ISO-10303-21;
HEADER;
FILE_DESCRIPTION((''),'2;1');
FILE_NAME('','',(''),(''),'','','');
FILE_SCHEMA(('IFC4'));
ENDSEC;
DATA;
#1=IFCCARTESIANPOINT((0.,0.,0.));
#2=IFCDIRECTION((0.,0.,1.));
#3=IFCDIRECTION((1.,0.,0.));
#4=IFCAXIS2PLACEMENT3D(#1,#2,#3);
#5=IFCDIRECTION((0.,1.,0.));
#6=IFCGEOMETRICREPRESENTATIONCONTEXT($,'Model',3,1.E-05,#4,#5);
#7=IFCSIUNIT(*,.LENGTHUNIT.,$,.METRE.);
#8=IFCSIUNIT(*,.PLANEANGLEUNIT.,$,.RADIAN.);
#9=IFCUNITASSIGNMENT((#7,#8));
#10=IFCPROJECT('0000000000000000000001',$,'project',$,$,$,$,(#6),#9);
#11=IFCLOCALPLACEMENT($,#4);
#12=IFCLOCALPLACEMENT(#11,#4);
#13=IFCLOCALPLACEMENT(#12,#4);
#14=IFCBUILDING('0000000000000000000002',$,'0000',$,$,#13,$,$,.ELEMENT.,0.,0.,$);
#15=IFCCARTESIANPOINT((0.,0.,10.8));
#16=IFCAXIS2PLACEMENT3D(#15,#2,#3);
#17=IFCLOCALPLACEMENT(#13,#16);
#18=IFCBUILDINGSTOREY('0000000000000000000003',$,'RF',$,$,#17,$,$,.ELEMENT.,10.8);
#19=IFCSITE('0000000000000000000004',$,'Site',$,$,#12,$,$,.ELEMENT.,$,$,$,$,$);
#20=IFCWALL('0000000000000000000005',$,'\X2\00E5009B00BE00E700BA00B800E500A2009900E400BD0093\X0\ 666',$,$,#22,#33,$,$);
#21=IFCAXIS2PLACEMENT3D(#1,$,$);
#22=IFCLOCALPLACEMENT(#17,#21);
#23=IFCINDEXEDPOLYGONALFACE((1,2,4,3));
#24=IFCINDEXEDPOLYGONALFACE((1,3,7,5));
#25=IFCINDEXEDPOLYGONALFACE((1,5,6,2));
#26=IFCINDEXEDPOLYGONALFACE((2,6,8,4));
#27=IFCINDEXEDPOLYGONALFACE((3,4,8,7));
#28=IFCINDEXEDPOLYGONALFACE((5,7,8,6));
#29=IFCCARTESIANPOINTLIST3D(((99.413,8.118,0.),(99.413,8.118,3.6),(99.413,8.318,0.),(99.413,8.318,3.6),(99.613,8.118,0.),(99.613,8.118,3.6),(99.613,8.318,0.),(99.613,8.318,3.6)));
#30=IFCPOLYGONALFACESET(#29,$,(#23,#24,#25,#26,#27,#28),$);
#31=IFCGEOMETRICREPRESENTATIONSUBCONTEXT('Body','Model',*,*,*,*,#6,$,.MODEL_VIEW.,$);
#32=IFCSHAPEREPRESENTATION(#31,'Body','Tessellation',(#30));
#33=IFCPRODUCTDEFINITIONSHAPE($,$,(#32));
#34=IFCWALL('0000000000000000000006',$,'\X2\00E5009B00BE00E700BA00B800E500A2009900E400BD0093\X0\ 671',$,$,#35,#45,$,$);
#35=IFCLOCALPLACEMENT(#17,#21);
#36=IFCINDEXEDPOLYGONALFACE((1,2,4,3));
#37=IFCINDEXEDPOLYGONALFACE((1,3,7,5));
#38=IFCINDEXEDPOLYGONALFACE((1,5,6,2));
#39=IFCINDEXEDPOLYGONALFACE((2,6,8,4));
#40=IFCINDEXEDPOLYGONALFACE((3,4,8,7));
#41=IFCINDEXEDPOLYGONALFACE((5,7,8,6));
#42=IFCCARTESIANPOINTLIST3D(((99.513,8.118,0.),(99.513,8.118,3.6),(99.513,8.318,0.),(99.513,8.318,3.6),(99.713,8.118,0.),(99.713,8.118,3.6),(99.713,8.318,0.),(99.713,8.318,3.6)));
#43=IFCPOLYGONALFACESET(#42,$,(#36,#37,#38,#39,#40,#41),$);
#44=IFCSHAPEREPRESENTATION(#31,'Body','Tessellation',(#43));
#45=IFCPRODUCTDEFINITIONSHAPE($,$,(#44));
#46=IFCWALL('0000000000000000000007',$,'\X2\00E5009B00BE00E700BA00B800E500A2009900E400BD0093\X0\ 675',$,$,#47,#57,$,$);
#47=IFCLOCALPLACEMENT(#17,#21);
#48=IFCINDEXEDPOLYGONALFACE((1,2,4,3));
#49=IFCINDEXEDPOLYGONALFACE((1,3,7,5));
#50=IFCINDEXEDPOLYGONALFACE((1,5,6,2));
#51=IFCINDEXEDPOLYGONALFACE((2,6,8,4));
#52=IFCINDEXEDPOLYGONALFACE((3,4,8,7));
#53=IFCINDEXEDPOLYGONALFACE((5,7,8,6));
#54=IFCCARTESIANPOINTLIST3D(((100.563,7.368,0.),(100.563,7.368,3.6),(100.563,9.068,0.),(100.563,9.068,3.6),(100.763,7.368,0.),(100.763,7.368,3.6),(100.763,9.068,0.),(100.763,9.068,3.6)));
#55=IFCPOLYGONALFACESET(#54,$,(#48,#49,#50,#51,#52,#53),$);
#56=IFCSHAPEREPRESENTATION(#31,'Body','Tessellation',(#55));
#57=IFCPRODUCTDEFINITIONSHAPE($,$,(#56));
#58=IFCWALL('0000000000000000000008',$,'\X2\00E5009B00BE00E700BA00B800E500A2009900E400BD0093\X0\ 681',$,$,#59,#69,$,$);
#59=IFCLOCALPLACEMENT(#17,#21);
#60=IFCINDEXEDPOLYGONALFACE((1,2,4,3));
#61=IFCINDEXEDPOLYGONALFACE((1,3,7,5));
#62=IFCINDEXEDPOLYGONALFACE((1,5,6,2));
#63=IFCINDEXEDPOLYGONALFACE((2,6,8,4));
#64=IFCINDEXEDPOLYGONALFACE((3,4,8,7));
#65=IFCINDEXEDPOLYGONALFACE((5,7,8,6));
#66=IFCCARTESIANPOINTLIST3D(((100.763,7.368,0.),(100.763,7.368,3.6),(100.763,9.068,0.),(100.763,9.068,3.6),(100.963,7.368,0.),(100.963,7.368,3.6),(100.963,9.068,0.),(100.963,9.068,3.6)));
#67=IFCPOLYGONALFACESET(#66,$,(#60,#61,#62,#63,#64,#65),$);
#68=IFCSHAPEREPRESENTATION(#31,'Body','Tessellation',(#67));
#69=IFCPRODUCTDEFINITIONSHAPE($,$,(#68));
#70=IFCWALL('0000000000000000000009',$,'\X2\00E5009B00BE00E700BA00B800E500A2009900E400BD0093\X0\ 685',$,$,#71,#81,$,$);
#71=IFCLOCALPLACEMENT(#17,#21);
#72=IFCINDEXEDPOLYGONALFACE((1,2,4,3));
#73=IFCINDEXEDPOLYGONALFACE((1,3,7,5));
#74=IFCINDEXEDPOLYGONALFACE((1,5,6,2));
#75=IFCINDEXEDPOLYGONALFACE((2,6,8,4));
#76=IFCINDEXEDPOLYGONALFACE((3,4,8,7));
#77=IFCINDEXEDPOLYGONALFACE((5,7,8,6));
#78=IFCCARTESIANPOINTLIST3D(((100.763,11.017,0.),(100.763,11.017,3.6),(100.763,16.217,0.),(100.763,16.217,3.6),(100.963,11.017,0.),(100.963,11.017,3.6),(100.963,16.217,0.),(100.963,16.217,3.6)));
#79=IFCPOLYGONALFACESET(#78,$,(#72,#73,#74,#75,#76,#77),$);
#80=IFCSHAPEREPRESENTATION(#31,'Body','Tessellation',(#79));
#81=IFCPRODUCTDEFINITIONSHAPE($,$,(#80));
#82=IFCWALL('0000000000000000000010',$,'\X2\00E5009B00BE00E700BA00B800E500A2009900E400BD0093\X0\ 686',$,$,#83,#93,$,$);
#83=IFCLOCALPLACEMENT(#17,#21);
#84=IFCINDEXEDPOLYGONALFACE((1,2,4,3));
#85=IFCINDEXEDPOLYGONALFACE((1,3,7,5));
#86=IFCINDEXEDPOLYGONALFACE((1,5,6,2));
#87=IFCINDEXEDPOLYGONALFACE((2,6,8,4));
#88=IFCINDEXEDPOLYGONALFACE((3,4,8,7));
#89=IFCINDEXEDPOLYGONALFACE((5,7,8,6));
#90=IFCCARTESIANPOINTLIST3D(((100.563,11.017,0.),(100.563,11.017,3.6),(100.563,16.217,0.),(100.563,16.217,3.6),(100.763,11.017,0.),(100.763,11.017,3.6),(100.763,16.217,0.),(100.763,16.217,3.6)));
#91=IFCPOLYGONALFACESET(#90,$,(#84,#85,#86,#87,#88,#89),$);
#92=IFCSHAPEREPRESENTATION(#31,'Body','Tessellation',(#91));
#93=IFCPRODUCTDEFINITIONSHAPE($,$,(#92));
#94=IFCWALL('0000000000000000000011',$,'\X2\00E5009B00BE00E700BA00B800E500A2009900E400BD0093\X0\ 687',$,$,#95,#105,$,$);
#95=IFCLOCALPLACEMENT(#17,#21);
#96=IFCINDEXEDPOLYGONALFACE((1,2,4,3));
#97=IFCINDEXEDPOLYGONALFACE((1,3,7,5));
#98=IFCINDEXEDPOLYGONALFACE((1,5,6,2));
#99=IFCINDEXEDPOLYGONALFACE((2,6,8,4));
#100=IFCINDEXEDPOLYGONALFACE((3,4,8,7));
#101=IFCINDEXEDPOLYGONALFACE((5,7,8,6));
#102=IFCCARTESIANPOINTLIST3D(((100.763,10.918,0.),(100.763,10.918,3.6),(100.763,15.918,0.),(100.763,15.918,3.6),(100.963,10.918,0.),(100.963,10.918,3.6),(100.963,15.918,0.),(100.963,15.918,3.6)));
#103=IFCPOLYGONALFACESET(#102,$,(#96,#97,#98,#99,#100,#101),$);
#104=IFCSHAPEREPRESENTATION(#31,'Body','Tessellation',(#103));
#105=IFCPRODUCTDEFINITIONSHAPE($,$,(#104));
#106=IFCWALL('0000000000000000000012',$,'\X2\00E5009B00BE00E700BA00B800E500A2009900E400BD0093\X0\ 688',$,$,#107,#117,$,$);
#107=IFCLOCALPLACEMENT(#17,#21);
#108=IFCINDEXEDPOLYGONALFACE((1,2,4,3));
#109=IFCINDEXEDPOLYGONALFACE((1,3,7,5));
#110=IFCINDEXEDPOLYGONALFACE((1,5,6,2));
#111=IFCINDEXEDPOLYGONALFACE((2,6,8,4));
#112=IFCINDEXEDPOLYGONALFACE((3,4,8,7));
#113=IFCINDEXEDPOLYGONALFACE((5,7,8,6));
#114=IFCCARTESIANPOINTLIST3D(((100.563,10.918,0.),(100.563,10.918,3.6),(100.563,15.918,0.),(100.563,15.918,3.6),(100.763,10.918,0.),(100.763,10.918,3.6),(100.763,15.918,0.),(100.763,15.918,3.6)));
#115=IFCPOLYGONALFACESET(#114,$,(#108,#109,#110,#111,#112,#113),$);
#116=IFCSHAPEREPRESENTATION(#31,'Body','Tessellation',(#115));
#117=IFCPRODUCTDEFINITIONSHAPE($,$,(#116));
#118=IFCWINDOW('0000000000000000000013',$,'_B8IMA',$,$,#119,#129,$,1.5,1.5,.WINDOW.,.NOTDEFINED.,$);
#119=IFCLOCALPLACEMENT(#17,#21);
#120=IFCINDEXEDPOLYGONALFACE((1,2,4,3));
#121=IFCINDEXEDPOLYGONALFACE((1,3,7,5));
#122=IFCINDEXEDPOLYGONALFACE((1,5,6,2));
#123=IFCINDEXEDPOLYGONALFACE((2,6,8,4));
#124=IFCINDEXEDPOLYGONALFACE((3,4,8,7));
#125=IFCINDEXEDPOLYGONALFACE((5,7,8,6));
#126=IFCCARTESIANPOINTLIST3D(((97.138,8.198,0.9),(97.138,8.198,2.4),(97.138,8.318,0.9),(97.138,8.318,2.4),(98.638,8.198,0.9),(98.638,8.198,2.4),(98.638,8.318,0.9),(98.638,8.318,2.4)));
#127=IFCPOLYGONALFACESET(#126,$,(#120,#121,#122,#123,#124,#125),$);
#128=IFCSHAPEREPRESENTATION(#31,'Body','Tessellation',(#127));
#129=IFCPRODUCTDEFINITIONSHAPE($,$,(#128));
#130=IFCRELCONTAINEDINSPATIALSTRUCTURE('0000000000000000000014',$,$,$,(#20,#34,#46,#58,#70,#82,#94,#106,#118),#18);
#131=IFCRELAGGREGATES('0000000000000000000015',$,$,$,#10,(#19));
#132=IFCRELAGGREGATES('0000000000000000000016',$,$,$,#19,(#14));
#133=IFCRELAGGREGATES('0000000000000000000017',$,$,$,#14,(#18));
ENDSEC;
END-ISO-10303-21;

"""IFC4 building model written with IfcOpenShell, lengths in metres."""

from ifc_helpers import new_model, si_unit, direction, frame, frame_2d, origin_with_axes, place, context, subcontext, project, spatial, rectangle, extrude, element, save


model = new_model("IFC4")

# Units and contexts
model_context = context("Model", 3, precision=1e-05, world=origin_with_axes(), true_north=direction((0.0, 1.0, 0.0)))
body_context = subcontext(model_context, "Body", "Model", "MODEL_VIEW")
ifc_project = project(units=[si_unit("LENGTHUNIT", "METRE"), si_unit("PLANEANGLEUNIT", "RADIAN")], contexts=[model_context])

# Site, building, storey
placement = place(None, origin_with_axes())
site_placement = place(placement, origin_with_axes())
site = spatial("IfcSite", under=ifc_project, at=site_placement, Name="Site", CompositionType="ELEMENT")
building_placement = place(site_placement, origin_with_axes())
building = spatial("IfcBuilding", under=site, at=building_placement, Name="0000", CompositionType="ELEMENT", ElevationOfRefHeight=0.0, ElevationOfTerrain=0.0)
storey_placement = place(building_placement, frame((0.0, 0.0, 10.8), z_axis=(0.0, 0.0, 1.0), x_axis=(1.0, 0.0, 0.0)))
storey = spatial("IfcBuildingStorey", under=building, at=storey_placement, Name="RF", CompositionType="ELEMENT", Elevation=10.8)

# Walls
for number, where, z_axis, x_axis, name in (
    (1, (99.513, 8.218, 0.0), (0.0, 0.0, 1.0), (0.0, 1.0, 0.0), "å\u009b¾çº¸å¢\u0099ä½\u0093 666"),
    (2, (99.613, 8.218, 0.0), (0.0, 0.0, 1.0), (0.0, -1.0, 0.0), "å\u009b¾çº¸å¢\u0099ä½\u0093 671"),
):
    element("IfcWall", number, at=place(storey_placement, frame(where, z_axis=z_axis, x_axis=x_axis)), inside=storey, Name=name, context=body_context, shape_type="SweptSolid", body=[
        extrude(rectangle(XDim=0.2, YDim=0.2, at=frame_2d((0.0, 0.0), x_axis=(1.0, 0.0, 0.0))), frame((0.0, 0.0, 0.0), z_axis=(0.0, 0.0, 1.0)), (0.0, 0.0, 1.0), 3.6),
    ])
for number, where, z_axis, x_axis, name in (
    (3, (100.663, 8.218, 0.0), (0.0, 0.0, 1.0), (0.0, -1.0, 0.0), "å\u009b¾çº¸å¢\u0099ä½\u0093 675"),
    (4, (100.863, 8.218, 0.0), (0.0, 0.0, 1.0), (0.0, -1.0, 0.0), "å\u009b¾çº¸å¢\u0099ä½\u0093 681"),
):
    element("IfcWall", number, at=place(storey_placement, frame(where, z_axis=z_axis, x_axis=x_axis)), inside=storey, Name=name, context=body_context, shape_type="SweptSolid", body=[
        extrude(rectangle(XDim=1.7, YDim=0.2, at=frame_2d((0.0, 0.0), x_axis=(1.0, 0.0, 0.0))), frame((0.0, 0.0, 0.0), z_axis=(0.0, 0.0, 1.0)), (0.0, 0.0, 1.0), 3.6),
    ])
for number, where, z_axis, x_axis, name in (
    (5, (100.863, 13.617, 0.0), (0.0, 0.0, 1.0), (0.0, -1.0, 0.0), "å\u009b¾çº¸å¢\u0099ä½\u0093 685"),
    (6, (100.663, 13.617, 0.0), (0.0, 0.0, 1.0), (0.0, -1.0, 0.0), "å\u009b¾çº¸å¢\u0099ä½\u0093 686"),
):
    element("IfcWall", number, at=place(storey_placement, frame(where, z_axis=z_axis, x_axis=x_axis)), inside=storey, Name=name, context=body_context, shape_type="SweptSolid", body=[
        extrude(rectangle(XDim=5.2, YDim=0.2, at=frame_2d((0.0, 0.0), x_axis=(1.0, 0.0, 0.0))), frame((0.0, 0.0, 0.0), z_axis=(0.0, 0.0, 1.0)), (0.0, 0.0, 1.0), 3.6),
    ])
for number, where, z_axis, x_axis, name in (
    (7, (100.863, 13.418, 0.0), (0.0, 0.0, 1.0), (0.0, -1.0, 0.0), "å\u009b¾çº¸å¢\u0099ä½\u0093 687"),
    (8, (100.663, 13.418, 0.0), (0.0, 0.0, 1.0), (0.0, -1.0, 0.0), "å\u009b¾çº¸å¢\u0099ä½\u0093 688"),
):
    element("IfcWall", number, at=place(storey_placement, frame(where, z_axis=z_axis, x_axis=x_axis)), inside=storey, Name=name, context=body_context, shape_type="SweptSolid", body=[
        extrude(rectangle(XDim=5.0, YDim=0.2, at=frame_2d((0.0, 0.0), x_axis=(1.0, 0.0, 0.0))), frame((0.0, 0.0, 0.0), z_axis=(0.0, 0.0, 1.0)), (0.0, 0.0, 1.0), 3.6),
    ])

# Window
window_placement = place(storey_placement, frame((97.888, 8.258, 0.9), z_axis=(0.0, 0.0, 1.0), x_axis=(1.0, 0.0, 0.0)))
element("IfcWindow", 9, at=window_placement, inside=storey, Name="_B8IMA", OverallHeight=1.5, OverallWidth=1.5, PartitioningType="NOTDEFINED", PredefinedType="WINDOW", context=body_context, shape_type="SweptSolid", body=[
    extrude(rectangle(XDim=1.5, YDim=0.12, at=frame_2d((0.0, 0.0), x_axis=(1.0, 0.0, 0.0))), frame((0.0, 0.0, 0.0), z_axis=(0.0, 0.0, 1.0)), (0.0, 0.0, 1.0), 1.5),
])

save(model, "model.ifc")
